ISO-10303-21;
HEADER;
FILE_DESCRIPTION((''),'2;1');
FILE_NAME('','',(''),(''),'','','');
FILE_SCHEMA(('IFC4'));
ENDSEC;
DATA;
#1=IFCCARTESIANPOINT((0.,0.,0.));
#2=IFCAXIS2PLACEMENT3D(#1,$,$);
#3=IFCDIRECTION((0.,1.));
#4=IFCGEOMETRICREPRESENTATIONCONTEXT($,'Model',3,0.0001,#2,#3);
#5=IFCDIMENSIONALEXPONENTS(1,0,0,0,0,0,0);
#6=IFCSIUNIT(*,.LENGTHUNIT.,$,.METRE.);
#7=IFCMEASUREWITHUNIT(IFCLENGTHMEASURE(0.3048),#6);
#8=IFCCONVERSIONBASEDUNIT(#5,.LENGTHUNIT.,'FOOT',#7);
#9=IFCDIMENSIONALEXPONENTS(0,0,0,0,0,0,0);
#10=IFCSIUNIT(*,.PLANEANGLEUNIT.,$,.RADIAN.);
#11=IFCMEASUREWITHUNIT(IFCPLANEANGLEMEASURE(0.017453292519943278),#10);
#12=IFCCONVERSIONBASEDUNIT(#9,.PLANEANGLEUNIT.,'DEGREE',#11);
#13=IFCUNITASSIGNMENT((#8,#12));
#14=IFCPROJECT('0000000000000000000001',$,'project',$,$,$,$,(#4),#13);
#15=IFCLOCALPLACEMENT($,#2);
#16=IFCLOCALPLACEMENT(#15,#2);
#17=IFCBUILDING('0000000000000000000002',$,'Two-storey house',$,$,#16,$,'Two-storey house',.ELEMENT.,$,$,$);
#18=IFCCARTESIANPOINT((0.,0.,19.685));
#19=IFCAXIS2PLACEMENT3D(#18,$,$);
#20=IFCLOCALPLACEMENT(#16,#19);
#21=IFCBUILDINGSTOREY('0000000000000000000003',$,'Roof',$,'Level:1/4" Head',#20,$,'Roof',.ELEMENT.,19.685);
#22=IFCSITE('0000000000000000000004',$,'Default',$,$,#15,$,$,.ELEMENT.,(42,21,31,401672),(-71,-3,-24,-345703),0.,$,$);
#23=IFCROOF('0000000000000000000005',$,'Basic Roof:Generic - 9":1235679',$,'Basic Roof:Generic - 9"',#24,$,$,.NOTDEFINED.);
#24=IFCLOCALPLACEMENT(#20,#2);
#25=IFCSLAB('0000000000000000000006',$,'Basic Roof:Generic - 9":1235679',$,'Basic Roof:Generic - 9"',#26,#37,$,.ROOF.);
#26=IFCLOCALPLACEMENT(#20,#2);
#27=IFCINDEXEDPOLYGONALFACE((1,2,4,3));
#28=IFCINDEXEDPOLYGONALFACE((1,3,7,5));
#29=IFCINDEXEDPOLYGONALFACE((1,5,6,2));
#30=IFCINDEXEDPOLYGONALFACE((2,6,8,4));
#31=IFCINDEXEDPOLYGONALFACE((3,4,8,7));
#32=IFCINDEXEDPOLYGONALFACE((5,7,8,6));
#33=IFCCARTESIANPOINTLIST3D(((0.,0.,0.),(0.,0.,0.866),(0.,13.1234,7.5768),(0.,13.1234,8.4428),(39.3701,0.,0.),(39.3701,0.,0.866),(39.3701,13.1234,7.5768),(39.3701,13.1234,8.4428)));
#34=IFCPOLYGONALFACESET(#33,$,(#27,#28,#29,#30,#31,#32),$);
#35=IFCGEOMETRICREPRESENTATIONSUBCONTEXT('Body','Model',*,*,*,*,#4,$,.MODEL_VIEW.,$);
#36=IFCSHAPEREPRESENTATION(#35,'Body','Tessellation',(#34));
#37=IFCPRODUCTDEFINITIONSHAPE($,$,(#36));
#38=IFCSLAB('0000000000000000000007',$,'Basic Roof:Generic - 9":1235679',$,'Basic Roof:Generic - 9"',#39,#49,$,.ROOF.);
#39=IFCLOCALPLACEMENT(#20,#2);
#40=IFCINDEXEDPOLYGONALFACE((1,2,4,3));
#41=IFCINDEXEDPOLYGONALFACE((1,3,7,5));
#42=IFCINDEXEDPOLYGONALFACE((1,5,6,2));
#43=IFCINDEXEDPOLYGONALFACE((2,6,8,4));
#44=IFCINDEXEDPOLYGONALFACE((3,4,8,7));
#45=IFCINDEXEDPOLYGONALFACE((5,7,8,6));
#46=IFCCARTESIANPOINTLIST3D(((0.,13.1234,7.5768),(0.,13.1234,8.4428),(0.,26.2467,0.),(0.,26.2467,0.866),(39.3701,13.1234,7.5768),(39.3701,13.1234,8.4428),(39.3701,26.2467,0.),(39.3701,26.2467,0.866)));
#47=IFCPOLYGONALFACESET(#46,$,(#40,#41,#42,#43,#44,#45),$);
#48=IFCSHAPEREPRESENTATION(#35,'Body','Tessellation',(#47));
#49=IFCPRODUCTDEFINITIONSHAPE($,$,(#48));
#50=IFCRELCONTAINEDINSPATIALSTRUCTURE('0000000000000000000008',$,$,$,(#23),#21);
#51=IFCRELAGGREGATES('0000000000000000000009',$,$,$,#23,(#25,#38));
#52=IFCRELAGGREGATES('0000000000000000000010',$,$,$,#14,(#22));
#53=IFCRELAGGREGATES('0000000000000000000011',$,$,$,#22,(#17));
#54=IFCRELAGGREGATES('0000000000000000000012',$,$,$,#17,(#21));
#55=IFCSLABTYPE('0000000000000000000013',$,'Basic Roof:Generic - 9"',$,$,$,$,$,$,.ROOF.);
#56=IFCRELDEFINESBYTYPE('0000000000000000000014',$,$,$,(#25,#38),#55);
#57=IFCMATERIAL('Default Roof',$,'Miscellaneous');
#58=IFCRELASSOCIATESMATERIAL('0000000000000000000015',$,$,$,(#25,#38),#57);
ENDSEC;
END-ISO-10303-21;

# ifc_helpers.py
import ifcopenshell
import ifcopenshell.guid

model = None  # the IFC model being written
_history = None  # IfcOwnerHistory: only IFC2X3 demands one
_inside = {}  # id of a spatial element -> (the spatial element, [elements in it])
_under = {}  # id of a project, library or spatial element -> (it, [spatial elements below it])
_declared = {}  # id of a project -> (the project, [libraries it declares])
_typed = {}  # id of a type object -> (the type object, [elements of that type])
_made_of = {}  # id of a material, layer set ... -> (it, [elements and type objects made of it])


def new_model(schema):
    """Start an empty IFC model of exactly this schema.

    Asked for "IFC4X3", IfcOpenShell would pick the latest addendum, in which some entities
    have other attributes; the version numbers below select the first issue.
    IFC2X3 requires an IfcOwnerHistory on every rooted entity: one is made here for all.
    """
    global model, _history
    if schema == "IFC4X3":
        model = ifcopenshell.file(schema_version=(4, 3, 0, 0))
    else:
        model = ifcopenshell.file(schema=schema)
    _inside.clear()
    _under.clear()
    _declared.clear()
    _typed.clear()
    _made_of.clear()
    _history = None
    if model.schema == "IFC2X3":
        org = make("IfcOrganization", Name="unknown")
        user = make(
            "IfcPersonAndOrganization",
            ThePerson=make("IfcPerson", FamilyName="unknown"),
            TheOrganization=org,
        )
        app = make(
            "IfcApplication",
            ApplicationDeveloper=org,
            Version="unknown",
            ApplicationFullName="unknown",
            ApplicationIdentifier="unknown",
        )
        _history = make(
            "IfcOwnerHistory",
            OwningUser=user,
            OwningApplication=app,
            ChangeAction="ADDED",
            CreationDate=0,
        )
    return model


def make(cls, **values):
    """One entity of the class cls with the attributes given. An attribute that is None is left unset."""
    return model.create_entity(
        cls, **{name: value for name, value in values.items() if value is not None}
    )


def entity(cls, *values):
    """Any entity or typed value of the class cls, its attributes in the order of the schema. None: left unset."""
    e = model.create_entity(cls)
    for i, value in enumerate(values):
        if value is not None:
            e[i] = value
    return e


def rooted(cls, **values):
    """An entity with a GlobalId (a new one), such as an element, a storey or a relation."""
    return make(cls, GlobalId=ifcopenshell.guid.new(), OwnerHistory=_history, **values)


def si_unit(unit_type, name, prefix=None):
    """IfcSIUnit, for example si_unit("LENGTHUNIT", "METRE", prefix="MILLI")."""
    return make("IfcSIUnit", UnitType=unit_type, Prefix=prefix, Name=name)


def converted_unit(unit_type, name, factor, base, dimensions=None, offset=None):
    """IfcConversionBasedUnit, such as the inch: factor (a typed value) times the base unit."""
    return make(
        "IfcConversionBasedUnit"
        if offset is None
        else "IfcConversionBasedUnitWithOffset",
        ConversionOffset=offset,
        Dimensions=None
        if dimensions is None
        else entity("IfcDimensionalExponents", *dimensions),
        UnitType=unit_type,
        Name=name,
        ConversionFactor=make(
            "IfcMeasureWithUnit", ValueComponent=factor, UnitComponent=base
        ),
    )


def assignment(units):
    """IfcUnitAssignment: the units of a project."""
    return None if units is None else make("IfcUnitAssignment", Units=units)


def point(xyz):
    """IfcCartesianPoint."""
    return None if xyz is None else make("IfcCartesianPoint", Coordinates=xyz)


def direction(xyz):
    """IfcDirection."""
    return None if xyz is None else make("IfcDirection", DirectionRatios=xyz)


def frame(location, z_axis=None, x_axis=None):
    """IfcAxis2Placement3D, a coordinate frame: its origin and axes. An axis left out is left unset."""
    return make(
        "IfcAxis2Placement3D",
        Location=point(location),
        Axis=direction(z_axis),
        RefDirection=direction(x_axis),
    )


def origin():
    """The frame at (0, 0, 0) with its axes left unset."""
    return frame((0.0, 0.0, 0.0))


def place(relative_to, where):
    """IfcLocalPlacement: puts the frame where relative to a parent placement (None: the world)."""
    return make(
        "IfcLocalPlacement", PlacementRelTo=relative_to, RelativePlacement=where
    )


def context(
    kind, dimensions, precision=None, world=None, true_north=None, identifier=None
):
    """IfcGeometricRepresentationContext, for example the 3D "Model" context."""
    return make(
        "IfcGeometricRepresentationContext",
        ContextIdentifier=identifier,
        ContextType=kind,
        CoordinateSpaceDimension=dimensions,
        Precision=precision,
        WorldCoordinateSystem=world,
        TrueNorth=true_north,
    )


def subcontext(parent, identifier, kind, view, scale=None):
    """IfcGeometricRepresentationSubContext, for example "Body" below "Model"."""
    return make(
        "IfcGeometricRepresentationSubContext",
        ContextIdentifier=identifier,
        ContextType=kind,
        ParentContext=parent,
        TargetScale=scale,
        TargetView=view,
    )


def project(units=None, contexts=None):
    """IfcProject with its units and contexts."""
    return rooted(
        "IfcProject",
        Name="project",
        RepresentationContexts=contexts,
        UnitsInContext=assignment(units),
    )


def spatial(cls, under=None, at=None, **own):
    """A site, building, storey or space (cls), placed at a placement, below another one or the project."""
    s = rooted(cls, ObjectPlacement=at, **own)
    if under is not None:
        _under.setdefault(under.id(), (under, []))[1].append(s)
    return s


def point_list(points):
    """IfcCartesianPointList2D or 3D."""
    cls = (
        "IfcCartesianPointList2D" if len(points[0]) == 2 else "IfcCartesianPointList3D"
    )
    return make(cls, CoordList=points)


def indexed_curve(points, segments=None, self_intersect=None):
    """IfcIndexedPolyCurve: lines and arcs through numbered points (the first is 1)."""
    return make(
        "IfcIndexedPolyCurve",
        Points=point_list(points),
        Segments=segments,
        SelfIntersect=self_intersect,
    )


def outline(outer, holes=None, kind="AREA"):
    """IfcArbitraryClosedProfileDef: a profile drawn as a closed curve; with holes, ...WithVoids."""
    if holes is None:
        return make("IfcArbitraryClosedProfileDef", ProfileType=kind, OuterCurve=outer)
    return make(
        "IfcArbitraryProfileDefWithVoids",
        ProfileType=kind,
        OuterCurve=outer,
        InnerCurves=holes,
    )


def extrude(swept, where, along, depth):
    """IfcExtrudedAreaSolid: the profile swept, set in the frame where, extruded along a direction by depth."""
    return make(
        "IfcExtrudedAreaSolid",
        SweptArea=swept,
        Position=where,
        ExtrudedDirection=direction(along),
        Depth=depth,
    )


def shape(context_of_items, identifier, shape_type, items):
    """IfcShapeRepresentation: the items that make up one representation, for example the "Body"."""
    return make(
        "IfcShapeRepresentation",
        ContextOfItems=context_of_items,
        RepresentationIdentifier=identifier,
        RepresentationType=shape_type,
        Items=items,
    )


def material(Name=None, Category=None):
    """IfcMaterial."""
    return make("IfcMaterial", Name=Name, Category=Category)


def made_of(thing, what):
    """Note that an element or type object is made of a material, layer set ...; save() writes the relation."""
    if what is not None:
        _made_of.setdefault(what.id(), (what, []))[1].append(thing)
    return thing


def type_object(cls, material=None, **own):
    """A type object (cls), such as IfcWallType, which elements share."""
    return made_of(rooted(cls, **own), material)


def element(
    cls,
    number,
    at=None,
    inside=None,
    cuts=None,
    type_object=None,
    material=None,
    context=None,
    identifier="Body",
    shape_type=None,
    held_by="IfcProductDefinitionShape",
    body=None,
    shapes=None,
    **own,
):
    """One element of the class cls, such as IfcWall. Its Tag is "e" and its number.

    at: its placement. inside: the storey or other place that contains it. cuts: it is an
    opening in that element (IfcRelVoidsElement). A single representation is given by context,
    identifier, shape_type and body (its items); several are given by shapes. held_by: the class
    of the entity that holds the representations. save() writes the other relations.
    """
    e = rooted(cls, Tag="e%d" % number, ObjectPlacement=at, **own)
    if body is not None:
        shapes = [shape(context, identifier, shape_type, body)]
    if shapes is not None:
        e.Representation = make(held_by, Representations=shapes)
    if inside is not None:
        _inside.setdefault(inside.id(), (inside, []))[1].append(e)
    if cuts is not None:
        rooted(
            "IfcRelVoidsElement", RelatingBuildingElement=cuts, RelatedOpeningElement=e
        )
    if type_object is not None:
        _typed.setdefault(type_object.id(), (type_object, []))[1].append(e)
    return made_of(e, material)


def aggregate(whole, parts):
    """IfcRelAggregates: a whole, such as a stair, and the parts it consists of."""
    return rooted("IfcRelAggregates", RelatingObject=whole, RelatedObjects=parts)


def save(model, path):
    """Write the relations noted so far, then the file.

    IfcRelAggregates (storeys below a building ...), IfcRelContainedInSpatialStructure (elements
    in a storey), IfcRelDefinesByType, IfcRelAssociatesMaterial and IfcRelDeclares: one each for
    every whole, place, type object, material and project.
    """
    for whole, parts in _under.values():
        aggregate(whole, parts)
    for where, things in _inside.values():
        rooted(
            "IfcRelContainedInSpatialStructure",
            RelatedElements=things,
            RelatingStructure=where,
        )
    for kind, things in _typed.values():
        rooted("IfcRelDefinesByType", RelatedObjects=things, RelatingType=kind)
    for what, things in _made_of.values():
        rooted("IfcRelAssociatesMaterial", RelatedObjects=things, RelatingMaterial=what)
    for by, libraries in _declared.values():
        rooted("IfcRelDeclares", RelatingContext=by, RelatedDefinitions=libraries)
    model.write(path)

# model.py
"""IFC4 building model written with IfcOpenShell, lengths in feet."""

from ifc_helpers import new_model, entity, si_unit, converted_unit, direction, frame, origin, place, context, subcontext, project, spatial, indexed_curve, outline, extrude, material, type_object, element, aggregate, save


model = new_model("IFC4")

# Units and contexts
model_context = context("Model", 3, precision=0.0001, world=origin(), true_north=direction((0.0, 1.0)))
body_context = subcontext(model_context, "Body", "Model", "MODEL_VIEW")
ifc_project = project(units=[converted_unit("LENGTHUNIT", "FOOT", entity("IfcLengthMeasure", 0.3048), si_unit("LENGTHUNIT", "METRE"), dimensions=[1, 0, 0, 0, 0, 0, 0]), converted_unit("PLANEANGLEUNIT", "DEGREE", entity("IfcPlaneAngleMeasure", 0.017453292519943278), si_unit("PLANEANGLEUNIT", "RADIAN"), dimensions=[0, 0, 0, 0, 0, 0, 0])], contexts=[model_context])

# Site, building, storey
site_placement = place(None, origin())
site = spatial("IfcSite", under=ifc_project, at=site_placement, Name="Default", CompositionType="ELEMENT", RefLatitude=(42, 21, 31, 401672), RefLongitude=(-71, -3, -24, -345703), RefElevation=0.0)
building_placement = place(site_placement, origin())
building = spatial("IfcBuilding", under=site, at=building_placement, Name="Two-storey house", LongName="Two-storey house", CompositionType="ELEMENT")
storey_placement = place(building_placement, frame((0.0, 0.0, 19.685)))
storey = spatial("IfcBuildingStorey", under=building, at=storey_placement, Name="Roof", ObjectType="Level:1/4\" Head", LongName="Roof", CompositionType="ELEMENT", Elevation=19.685)

# Roof, slabs
roof_placement = place(storey_placement, origin())
roof = element("IfcRoof", 1, at=roof_placement, inside=storey, Name="Basic Roof:Generic - 9\":1235679", ObjectType="Basic Roof:Generic - 9\"", PredefinedType="NOTDEFINED")
ifc_material = material(Name="Default Roof", Category="Miscellaneous")
slab_type = type_object("IfcSlabType", Name="Basic Roof:Generic - 9\"", PredefinedType="ROOF")
slab_1_placement = place(roof_placement, origin())
slab_1 = element("IfcSlab", 2, at=slab_1_placement, type_object=slab_type, material=ifc_material, Name="Basic Roof:Generic - 9\":1235679", ObjectType="Basic Roof:Generic - 9\"", PredefinedType="ROOF", context=body_context, shape_type="SweptSolid", body=[
    extrude(outline(indexed_curve([(19.685, 7.5768), (-19.685, 7.5768), (-19.685, -7.5768), (19.685, -7.5768), (19.685, 7.5768)], self_intersect=False)), frame((19.685, 6.5617, 3.7884), z_axis=(0.0, -0.5, 0.866025), x_axis=(1.0, 0.0, 0.0)), (0.0, 0.5, 0.866025), 0.866),
])
slab_2_placement = place(roof_placement, origin())
slab_2 = element("IfcSlab", 3, at=slab_2_placement, type_object=slab_type, material=ifc_material, Name="Basic Roof:Generic - 9\":1235679", ObjectType="Basic Roof:Generic - 9\"", PredefinedType="ROOF", context=body_context, shape_type="SweptSolid", body=[
    extrude(outline(indexed_curve([(-19.685, 7.5768), (-19.685, -7.5768), (19.685, -7.5768), (19.685, 7.5768), (-19.685, 7.5768)], self_intersect=False)), frame((19.685, 19.685, 3.7884), z_axis=(0.0, 0.5, 0.866025), x_axis=(1.0, 0.0, 0.0)), (0.0, -0.5, 0.866025), 0.866),
])
aggregate(roof, [slab_1, slab_2])

save(model, "model.ifc")
